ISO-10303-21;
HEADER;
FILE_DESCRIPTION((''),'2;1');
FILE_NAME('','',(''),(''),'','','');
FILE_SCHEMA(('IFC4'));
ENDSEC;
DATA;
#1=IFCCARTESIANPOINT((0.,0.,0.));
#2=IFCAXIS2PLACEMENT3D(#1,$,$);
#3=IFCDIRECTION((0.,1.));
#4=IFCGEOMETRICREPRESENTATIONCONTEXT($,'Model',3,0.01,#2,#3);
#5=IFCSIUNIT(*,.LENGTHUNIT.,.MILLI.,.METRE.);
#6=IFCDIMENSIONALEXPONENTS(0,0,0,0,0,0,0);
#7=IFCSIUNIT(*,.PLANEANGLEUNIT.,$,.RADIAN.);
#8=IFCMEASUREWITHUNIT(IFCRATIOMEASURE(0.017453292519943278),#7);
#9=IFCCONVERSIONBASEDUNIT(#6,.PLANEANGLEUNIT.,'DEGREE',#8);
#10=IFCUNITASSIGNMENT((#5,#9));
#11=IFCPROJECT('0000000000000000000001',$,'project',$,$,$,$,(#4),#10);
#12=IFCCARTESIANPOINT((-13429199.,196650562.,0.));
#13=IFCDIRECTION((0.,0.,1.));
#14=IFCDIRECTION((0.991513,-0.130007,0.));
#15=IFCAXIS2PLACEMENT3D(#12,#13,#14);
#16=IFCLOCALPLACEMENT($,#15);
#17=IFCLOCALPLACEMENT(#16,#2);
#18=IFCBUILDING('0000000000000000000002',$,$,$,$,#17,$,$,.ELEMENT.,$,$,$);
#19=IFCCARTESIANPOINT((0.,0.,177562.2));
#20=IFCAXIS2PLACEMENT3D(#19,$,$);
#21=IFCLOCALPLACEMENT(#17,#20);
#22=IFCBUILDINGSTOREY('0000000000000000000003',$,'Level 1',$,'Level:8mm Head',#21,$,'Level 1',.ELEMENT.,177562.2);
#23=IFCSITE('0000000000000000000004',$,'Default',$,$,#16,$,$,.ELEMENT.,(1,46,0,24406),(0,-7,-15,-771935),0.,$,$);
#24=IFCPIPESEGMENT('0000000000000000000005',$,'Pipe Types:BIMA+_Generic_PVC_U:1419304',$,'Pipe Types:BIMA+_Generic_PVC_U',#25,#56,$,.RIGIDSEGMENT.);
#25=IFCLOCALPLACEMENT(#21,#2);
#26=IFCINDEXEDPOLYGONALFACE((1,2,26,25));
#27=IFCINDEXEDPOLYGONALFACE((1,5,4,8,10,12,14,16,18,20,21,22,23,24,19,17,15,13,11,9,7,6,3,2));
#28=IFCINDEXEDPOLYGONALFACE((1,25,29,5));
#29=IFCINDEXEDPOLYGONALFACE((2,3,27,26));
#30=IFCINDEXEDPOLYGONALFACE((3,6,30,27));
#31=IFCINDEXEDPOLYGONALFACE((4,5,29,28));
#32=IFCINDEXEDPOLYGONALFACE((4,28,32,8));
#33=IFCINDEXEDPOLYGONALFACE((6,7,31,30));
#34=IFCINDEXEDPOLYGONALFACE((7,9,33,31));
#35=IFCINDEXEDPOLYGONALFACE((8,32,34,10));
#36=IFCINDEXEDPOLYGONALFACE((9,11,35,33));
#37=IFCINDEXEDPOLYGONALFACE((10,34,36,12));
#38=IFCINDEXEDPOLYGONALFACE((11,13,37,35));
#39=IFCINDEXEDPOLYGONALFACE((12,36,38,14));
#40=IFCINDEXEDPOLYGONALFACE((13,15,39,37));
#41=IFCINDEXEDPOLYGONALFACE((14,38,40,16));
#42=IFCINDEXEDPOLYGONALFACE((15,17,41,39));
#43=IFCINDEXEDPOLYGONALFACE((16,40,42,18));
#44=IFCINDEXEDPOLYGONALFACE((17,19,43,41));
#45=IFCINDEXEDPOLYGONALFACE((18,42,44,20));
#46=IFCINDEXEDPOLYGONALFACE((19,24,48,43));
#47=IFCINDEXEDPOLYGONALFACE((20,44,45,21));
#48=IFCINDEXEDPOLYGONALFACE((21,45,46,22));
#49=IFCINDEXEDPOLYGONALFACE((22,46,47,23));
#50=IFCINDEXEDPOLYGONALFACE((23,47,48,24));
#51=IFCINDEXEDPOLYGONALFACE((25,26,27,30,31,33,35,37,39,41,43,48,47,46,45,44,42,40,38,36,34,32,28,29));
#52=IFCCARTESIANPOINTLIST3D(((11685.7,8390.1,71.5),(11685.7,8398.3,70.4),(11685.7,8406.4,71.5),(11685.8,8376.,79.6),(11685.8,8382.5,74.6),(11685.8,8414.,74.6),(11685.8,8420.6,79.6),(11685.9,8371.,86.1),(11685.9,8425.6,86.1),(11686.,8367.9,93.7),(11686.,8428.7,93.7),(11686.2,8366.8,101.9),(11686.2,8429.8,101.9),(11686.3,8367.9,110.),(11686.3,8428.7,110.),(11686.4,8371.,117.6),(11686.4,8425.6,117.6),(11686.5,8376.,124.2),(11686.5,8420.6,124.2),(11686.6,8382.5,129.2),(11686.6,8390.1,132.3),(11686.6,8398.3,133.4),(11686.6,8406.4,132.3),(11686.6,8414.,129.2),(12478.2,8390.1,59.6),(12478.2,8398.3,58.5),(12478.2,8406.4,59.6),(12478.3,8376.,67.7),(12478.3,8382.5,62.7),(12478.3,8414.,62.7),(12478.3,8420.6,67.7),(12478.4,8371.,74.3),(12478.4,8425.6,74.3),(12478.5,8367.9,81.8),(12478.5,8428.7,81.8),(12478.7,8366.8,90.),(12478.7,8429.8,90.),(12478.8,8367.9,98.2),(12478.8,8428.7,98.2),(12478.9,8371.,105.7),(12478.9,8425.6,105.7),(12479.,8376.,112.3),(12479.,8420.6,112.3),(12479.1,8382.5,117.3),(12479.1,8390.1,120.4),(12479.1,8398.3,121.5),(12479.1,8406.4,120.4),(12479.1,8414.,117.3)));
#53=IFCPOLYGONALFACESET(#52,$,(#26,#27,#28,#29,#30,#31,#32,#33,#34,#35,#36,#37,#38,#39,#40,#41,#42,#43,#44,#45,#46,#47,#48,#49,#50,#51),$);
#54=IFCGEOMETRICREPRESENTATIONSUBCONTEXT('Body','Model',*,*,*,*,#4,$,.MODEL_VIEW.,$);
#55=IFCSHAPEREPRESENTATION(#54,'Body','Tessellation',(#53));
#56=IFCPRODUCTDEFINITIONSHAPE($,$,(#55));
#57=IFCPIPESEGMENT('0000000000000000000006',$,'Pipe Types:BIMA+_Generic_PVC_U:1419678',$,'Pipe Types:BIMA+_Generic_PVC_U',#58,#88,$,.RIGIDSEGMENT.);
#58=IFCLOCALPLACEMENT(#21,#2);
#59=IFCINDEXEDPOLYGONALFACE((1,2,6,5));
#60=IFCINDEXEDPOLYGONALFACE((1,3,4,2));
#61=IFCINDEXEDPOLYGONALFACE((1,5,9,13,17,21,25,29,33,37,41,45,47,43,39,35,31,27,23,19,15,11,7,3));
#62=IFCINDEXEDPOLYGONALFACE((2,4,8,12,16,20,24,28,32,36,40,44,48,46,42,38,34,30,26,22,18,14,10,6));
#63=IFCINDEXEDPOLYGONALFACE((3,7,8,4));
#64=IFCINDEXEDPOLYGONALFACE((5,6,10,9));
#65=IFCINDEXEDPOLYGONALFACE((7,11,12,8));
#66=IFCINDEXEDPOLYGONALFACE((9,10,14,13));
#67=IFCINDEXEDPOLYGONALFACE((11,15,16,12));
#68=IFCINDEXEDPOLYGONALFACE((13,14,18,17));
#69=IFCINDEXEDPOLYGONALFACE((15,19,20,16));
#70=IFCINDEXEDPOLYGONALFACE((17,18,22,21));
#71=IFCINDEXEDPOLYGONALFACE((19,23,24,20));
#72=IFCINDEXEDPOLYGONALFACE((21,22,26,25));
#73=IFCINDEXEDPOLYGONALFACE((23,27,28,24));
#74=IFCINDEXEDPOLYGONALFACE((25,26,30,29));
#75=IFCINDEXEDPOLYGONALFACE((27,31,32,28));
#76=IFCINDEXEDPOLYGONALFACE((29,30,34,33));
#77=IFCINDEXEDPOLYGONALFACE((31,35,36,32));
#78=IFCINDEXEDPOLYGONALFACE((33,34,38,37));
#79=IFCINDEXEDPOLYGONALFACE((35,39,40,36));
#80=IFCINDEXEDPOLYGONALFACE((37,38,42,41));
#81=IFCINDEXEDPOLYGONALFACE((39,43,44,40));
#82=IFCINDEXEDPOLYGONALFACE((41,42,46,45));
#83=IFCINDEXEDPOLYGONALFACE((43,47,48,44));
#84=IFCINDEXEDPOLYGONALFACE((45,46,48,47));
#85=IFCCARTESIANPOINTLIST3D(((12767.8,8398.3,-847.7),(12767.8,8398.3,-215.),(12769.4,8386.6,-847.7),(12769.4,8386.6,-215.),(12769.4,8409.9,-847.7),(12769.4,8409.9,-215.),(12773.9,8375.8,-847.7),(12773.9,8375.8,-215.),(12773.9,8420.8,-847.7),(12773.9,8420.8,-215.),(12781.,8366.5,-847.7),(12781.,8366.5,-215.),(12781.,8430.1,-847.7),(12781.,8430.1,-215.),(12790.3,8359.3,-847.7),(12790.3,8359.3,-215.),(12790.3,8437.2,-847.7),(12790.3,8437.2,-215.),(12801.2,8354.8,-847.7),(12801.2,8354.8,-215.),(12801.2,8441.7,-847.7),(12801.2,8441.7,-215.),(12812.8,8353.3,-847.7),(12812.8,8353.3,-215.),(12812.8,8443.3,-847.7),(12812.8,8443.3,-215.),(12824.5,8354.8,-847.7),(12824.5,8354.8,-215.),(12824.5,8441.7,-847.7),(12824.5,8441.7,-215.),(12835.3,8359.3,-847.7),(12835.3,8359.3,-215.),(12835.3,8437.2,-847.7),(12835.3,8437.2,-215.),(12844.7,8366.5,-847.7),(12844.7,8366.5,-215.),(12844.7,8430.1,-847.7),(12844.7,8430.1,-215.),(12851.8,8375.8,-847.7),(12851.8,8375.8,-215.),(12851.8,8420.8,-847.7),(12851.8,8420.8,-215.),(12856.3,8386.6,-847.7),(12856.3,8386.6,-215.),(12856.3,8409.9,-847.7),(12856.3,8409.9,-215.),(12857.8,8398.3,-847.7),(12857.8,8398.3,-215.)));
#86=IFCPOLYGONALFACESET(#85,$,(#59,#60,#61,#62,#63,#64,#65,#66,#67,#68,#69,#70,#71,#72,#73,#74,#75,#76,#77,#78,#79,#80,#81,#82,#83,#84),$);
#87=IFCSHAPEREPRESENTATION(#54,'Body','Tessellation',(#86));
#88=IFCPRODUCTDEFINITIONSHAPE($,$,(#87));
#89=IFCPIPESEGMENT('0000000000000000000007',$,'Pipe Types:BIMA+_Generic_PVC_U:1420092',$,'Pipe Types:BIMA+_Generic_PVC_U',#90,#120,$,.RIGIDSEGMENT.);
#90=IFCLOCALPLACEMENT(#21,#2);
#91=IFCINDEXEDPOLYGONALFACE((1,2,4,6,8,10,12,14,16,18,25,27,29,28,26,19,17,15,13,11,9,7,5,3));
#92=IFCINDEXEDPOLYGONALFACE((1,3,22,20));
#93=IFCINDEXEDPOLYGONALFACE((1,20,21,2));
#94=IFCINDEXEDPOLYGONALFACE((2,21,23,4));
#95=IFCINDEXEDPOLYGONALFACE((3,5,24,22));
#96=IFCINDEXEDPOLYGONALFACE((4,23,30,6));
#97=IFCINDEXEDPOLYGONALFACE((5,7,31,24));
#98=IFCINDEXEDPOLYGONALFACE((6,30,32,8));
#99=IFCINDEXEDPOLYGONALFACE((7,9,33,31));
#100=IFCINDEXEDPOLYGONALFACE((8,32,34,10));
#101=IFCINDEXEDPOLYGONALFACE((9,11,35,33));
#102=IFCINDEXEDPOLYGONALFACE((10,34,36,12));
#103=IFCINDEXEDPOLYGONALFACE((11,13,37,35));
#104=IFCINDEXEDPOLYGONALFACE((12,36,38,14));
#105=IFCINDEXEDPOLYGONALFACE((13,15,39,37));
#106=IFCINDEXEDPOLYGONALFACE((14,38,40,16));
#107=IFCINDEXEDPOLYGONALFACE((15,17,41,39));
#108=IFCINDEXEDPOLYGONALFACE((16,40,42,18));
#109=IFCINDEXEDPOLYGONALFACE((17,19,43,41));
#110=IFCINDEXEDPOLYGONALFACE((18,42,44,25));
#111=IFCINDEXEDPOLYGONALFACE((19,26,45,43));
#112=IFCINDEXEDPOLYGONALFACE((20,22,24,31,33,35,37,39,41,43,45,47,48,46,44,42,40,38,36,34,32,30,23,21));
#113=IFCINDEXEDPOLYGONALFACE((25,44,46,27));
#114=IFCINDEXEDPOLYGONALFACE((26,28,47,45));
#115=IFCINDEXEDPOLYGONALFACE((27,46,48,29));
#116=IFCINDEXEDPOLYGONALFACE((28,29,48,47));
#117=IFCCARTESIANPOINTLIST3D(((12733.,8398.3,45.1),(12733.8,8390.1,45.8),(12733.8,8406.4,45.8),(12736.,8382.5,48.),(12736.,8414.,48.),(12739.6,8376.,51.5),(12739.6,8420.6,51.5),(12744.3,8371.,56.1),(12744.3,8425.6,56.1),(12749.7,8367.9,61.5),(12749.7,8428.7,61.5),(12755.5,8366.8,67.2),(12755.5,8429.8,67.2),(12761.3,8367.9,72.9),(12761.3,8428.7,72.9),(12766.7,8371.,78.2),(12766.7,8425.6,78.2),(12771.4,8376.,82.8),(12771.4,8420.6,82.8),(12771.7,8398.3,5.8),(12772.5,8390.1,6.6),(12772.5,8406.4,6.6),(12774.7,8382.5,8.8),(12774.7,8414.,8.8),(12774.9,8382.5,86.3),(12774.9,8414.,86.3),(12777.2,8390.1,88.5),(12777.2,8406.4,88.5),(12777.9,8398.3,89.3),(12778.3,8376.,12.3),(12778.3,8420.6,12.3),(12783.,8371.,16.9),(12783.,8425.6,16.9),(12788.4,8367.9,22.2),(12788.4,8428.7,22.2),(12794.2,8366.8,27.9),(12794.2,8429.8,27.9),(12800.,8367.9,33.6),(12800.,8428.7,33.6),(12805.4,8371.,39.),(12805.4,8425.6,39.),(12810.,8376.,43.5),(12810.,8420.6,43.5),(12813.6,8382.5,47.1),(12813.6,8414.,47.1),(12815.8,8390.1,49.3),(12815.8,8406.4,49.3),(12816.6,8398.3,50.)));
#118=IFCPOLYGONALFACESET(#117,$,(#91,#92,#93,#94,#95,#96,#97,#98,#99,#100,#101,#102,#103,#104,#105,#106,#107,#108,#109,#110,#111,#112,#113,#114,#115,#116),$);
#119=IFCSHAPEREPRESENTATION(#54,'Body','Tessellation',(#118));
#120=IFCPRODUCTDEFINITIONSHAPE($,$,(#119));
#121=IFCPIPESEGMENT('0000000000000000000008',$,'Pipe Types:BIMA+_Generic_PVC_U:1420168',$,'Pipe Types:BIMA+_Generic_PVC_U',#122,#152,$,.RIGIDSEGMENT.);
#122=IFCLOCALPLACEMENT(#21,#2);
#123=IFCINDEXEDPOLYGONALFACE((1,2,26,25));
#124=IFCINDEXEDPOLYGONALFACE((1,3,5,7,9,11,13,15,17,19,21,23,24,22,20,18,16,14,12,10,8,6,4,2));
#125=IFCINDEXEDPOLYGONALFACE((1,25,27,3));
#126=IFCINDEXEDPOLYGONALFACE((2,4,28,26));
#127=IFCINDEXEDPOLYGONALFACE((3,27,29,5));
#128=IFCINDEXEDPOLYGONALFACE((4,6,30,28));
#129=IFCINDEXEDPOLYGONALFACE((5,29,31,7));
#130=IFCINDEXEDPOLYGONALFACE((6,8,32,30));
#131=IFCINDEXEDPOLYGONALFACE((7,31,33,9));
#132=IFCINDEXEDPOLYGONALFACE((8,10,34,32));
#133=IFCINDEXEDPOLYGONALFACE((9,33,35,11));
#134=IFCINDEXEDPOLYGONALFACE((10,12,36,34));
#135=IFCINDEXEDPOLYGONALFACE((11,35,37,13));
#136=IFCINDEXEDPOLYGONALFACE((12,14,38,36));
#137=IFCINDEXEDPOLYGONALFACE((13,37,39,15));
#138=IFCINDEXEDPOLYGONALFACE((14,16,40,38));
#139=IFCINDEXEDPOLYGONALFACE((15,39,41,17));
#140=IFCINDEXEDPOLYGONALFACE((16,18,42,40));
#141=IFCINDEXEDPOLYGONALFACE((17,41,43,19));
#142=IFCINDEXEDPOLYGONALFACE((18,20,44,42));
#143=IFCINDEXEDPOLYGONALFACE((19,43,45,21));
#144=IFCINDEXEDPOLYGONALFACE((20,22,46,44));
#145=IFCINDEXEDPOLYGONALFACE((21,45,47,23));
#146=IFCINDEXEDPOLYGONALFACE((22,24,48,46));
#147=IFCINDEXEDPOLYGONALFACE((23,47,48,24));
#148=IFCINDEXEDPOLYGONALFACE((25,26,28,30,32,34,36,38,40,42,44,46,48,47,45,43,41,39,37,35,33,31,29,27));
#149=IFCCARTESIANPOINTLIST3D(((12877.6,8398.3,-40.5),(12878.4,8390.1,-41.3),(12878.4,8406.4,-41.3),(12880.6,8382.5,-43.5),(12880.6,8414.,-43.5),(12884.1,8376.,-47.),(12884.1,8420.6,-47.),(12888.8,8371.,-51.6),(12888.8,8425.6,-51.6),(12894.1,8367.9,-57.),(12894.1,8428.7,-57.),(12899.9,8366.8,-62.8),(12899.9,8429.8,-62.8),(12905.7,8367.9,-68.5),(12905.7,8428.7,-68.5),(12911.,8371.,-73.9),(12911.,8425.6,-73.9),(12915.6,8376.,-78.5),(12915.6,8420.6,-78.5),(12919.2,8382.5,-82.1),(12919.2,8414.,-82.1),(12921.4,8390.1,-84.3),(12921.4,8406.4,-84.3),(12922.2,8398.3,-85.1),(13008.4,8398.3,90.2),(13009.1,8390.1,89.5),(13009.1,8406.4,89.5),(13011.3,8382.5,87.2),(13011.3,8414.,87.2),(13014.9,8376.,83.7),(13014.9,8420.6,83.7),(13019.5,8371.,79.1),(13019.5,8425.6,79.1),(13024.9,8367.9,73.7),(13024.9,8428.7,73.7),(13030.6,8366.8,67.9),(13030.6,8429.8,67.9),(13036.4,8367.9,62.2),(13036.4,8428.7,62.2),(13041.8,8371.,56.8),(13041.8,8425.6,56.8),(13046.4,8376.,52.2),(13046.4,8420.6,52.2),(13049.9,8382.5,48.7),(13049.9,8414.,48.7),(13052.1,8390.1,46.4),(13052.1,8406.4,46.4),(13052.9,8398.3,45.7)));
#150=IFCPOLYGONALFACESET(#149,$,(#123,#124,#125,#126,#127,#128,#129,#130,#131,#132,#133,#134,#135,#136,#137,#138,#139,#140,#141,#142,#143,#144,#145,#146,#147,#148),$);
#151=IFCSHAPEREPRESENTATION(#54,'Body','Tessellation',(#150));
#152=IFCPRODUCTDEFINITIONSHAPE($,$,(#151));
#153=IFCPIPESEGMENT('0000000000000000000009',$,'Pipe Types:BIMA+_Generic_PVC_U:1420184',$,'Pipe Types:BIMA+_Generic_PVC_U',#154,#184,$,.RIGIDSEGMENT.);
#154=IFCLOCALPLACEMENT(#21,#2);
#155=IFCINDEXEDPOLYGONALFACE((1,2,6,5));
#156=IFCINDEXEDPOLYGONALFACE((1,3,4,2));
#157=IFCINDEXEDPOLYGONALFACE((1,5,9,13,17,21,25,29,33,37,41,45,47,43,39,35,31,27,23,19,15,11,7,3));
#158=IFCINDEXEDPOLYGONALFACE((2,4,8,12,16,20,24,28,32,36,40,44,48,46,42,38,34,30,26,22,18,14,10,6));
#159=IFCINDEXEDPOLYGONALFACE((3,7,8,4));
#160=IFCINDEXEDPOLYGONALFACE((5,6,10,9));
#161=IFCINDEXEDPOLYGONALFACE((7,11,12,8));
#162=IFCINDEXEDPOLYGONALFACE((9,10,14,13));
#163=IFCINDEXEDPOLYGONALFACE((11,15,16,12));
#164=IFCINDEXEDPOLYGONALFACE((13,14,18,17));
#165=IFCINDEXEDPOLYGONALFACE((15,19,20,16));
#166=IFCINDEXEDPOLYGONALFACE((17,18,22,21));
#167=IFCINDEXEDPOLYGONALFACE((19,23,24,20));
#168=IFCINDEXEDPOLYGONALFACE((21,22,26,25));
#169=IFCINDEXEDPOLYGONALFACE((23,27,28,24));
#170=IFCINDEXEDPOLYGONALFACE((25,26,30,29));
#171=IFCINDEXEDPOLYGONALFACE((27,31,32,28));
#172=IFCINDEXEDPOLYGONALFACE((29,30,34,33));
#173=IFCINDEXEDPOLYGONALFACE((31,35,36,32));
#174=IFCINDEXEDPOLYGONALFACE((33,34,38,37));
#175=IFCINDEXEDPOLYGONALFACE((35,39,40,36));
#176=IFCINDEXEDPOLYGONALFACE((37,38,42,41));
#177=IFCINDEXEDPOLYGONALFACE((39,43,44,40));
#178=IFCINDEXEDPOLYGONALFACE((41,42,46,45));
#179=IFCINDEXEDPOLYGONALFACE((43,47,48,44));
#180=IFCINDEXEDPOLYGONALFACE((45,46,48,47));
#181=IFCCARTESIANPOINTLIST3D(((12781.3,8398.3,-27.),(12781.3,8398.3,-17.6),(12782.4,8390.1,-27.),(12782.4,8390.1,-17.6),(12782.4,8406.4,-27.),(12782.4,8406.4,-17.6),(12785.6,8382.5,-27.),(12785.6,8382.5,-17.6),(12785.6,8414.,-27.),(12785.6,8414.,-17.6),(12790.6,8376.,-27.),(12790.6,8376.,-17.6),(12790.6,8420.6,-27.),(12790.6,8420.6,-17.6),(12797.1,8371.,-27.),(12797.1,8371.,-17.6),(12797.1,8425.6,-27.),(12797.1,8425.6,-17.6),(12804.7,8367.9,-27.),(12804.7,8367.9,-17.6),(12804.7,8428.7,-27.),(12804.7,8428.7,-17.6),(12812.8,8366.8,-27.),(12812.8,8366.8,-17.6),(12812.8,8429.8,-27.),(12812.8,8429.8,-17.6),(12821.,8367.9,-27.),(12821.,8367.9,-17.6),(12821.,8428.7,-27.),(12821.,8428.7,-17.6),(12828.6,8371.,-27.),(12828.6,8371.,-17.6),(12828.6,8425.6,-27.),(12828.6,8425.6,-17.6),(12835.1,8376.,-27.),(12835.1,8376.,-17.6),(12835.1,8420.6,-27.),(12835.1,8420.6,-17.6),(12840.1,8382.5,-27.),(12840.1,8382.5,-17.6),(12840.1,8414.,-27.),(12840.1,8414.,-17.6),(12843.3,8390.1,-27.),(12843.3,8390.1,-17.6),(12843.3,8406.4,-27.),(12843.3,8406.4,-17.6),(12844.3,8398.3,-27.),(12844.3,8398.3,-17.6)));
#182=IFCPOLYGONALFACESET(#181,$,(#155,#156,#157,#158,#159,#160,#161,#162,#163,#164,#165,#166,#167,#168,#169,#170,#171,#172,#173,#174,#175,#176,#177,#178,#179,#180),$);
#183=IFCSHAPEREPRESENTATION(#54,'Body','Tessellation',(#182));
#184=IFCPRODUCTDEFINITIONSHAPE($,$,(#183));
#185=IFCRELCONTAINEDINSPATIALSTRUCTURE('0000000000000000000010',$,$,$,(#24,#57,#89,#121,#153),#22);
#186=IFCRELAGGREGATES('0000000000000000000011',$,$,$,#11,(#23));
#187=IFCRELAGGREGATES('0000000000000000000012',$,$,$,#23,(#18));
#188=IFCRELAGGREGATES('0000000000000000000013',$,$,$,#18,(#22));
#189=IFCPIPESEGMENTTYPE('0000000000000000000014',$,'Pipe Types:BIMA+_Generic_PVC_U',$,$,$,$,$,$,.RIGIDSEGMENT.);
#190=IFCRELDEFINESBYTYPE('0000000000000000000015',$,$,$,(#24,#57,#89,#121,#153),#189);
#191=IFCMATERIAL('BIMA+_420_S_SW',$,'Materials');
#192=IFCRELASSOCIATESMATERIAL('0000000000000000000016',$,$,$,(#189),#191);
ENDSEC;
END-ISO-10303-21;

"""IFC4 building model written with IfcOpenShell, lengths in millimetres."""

from ifc_helpers import new_model, entity, si_unit, converted_unit, direction, frame, origin, place, context, subcontext, project, spatial, arc, indexed_curve, outline, extrude, material, type_object, element, save


model = new_model("IFC4")

# Units and contexts
model_context = context("Model", 3, precision=0.01, world=origin(), true_north=direction((0.0, 1.0)))
body_context = subcontext(model_context, "Body", "Model", "MODEL_VIEW")
ifc_project = project(units=[si_unit("LENGTHUNIT", "METRE", prefix="MILLI"), converted_unit("PLANEANGLEUNIT", "DEGREE", entity("IfcRatioMeasure", 0.017453292519943278), si_unit("PLANEANGLEUNIT", "RADIAN"), dimensions=[0, 0, 0, 0, 0, 0, 0])], contexts=[model_context])

# Site, building, storey
site_placement = place(None, frame((-13429199.0, 196650562.0, 0.0), z_axis=(0.0, 0.0, 1.0), x_axis=(0.991513, -0.130007, 0.0)))
site = spatial("IfcSite", under=ifc_project, at=site_placement, Name="Default", CompositionType="ELEMENT", RefLatitude=(1, 46, 0, 24406), RefLongitude=(0, -7, -15, -771935), RefElevation=0.0)
building_placement = place(site_placement, origin())
building = spatial("IfcBuilding", under=site, at=building_placement, CompositionType="ELEMENT")
storey_placement = place(building_placement, frame((0.0, 0.0, 177562.2)))
storey = spatial("IfcBuildingStorey", under=building, at=storey_placement, Name="Level 1", ObjectType="Level:8mm Head", LongName="Level 1", CompositionType="ELEMENT", Elevation=177562.2)

# Pipe segments
ifc_material_1 = material(Name="BIMA+_420_S_SW", Category="Materials")
pipe_segment_type_1 = type_object("IfcPipeSegmentType", Name="Pipe Types:BIMA+_Generic_PVC_U", PredefinedType="RIGIDSEGMENT", material=ifc_material_1)
pipe_segment_1_placement = place(storey_placement, frame((11684.1, 8365.2, 135.0)))
element("IfcPipeSegment", 1, at=pipe_segment_1_placement, inside=storey, type_object=pipe_segment_type_1, Name="Pipe Types:BIMA+_Generic_PVC_U:1419304", ObjectType="Pipe Types:BIMA+_Generic_PVC_U", PredefinedType="RIGIDSEGMENT", context=body_context, shape_type="SweptSolid", body=[
    extrude(outline(indexed_curve([(31.5, 0.0), (22.3, 22.3), (0.0, 31.5), (-22.3, 22.3), (-31.5, 0.0), (-22.3, -22.3), (0.0, -31.5), (22.3, -22.3)], segments=[arc(1, 2, 3), arc(3, 4, 5), arc(5, 6, 7), arc(7, 8, 1)], self_intersect=False)), frame((2.1, 33.1, -33.1), z_axis=(0.999888, 0.0, -0.014998), x_axis=(0.0, 1.0, 0.0)), (0.0, 0.0, 1.0), 792.6),
])
pipe_segment_2_placement = place(storey_placement, frame((12766.2, 8351.7, -215.0)))
element("IfcPipeSegment", 2, at=pipe_segment_2_placement, inside=storey, type_object=pipe_segment_type_1, Name="Pipe Types:BIMA+_Generic_PVC_U:1419678", ObjectType="Pipe Types:BIMA+_Generic_PVC_U", PredefinedType="RIGIDSEGMENT", context=body_context, shape_type="SweptSolid", body=[
    extrude(outline(indexed_curve([(45.0, 0.0), (31.8, 31.8), (0.0, 45.0), (-31.8, 31.8), (-45.0, 0.0), (-31.8, -31.8), (0.0, -45.0), (31.8, -31.8)], segments=[arc(1, 2, 3), arc(3, 4, 5), arc(5, 6, 7), arc(7, 8, 1)], self_intersect=False)), frame((46.6, 46.6, -632.7)), (0.0, 0.0, 1.0), 632.7),
])
pipe_segment_3_placement = place(storey_placement, frame((12731.4, 8365.2, 90.9)))
element("IfcPipeSegment", 3, at=pipe_segment_3_placement, inside=storey, type_object=pipe_segment_type_1, Name="Pipe Types:BIMA+_Generic_PVC_U:1420092", ObjectType="Pipe Types:BIMA+_Generic_PVC_U", PredefinedType="RIGIDSEGMENT", context=body_context, shape_type="SweptSolid", body=[
    extrude(outline(indexed_curve([(31.5, 0.0), (22.3, 22.3), (0.0, 31.5), (-22.3, 22.3), (-31.5, 0.0), (-22.3, -22.3), (0.0, -31.5), (22.3, -22.3)], segments=[arc(1, 2, 3), arc(3, 4, 5), arc(5, 6, 7), arc(7, 8, 1)], self_intersect=False)), frame((62.7, 33.1, -63.0), z_axis=(-0.701784, 0.0, 0.71239), x_axis=(0.0, 1.0, 0.0)), (0.0, 0.0, 1.0), 55.1),
])
pipe_segment_4_placement = place(storey_placement, frame((12876.0, 8365.2, -86.7)))
element("IfcPipeSegment", 4, at=pipe_segment_4_placement, inside=storey, type_object=pipe_segment_type_1, Name="Pipe Types:BIMA+_Generic_PVC_U:1420168", ObjectType="Pipe Types:BIMA+_Generic_PVC_U", PredefinedType="RIGIDSEGMENT", context=body_context, shape_type="SweptSolid", body=[
    extrude(outline(indexed_curve([(31.5, 0.0), (22.3, 22.3), (0.0, 31.5), (-22.3, 22.3), (-31.5, 0.0), (-22.3, -22.3), (0.0, -31.5), (22.3, -22.3)], segments=[arc(1, 2, 3), arc(3, 4, 5), arc(5, 6, 7), arc(7, 8, 1)], self_intersect=False)), frame((23.9, 33.1, 23.9), z_axis=(0.707107, 0.0, 0.707107), x_axis=(0.0, -1.0, 0.0)), (0.0, 0.0, 1.0), 184.9),
])
pipe_segment_5_placement = place(storey_placement, frame((12779.7, 8365.2, -27.0)))
element("IfcPipeSegment", 5, at=pipe_segment_5_placement, inside=storey, type_object=pipe_segment_type_1, Name="Pipe Types:BIMA+_Generic_PVC_U:1420184", ObjectType="Pipe Types:BIMA+_Generic_PVC_U", PredefinedType="RIGIDSEGMENT", context=body_context, shape_type="SweptSolid", body=[
    extrude(outline(indexed_curve([(31.5, 0.0), (22.3, 22.3), (0.0, 31.5), (-22.3, 22.3), (-31.5, 0.0), (-22.3, -22.3), (0.0, -31.5), (22.3, -22.3)], segments=[arc(1, 2, 3), arc(3, 4, 5), arc(5, 6, 7), arc(7, 8, 1)], self_intersect=False)), frame((33.1, 33.1, 0.0)), (0.0, 0.0, 1.0), 9.4),
])

save(model, "model.ifc")
